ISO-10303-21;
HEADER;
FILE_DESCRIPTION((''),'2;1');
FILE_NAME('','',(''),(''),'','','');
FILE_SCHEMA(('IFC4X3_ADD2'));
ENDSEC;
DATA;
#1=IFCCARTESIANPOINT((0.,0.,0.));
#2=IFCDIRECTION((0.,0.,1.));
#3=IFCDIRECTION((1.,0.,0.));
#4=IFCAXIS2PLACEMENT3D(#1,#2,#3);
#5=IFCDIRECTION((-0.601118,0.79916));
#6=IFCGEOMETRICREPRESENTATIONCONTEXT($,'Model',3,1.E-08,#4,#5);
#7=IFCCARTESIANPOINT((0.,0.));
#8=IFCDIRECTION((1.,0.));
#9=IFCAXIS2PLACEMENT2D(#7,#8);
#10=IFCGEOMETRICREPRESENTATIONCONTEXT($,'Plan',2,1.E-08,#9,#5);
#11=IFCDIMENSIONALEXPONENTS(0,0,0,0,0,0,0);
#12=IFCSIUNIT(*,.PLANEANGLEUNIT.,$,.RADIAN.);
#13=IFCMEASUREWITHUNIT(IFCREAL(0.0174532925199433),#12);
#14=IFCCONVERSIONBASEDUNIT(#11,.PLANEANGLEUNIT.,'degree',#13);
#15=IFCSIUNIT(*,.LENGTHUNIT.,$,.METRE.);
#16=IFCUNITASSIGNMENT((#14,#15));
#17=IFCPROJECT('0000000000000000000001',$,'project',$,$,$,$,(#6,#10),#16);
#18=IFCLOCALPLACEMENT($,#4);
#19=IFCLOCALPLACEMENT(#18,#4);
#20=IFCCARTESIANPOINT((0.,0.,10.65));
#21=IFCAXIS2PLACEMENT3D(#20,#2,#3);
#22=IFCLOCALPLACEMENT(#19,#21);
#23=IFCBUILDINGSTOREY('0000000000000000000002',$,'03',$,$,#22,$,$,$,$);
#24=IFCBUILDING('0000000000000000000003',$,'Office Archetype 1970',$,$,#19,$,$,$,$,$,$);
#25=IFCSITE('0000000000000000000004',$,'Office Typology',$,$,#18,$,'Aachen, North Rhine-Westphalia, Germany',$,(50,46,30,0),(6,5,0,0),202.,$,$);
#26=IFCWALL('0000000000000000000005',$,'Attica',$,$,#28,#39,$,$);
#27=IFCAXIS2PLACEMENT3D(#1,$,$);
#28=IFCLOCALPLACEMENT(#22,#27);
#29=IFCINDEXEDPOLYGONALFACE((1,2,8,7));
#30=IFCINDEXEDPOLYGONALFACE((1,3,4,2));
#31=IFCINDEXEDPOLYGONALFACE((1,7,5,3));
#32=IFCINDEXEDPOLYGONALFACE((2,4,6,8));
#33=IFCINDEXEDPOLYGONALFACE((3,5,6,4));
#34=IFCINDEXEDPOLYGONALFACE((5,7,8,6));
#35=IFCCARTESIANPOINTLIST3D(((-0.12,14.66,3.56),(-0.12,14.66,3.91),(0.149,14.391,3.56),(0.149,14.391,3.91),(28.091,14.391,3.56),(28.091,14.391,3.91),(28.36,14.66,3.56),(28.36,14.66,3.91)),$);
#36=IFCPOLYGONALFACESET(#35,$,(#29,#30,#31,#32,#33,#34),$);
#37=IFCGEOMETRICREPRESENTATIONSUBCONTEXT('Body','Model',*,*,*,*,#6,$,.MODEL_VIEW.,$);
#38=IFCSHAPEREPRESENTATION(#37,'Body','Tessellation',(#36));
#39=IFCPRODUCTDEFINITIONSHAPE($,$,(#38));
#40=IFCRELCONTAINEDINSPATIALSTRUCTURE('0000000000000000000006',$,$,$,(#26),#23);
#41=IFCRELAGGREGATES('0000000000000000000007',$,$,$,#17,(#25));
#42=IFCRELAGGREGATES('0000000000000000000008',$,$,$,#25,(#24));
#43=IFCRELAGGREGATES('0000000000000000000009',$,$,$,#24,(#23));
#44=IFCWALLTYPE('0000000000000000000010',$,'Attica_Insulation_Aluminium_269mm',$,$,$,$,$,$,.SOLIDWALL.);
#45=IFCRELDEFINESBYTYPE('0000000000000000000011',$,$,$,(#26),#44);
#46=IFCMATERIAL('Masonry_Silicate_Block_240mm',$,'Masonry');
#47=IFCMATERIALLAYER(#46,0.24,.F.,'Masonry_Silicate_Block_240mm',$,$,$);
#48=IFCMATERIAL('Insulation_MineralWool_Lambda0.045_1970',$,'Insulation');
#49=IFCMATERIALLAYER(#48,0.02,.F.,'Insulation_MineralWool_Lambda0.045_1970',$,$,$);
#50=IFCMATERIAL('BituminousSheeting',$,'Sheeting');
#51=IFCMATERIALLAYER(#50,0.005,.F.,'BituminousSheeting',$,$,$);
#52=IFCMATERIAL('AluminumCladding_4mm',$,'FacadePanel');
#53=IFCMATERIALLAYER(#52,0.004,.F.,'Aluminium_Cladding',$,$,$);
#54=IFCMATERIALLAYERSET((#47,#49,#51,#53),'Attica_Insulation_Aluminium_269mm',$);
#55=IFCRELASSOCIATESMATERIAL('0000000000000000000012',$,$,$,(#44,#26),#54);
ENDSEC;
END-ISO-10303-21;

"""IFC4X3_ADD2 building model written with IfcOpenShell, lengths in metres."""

from ifc_helpers import new_model, entity, si_unit, converted_unit, direction, frame, origin_with_axes, origin_2d_with_axis, place, context, subcontext, project, spatial, line, indexed_curve, outline, extrude, material, layer, layer_set, layer_usage, type_object, element, save


model = new_model("IFC4X3_ADD2")

# Units and contexts
model_context = context("Model", 3, precision=1e-08, world=origin_with_axes(), true_north=direction((-0.601118, 0.79916)))
plan_context = context("Plan", 2, precision=1e-08, world=origin_2d_with_axis(), true_north=direction((-0.601118, 0.79916)))
body_context = subcontext(model_context, "Body", "Model", "MODEL_VIEW")
ifc_project = project(units=[converted_unit("PLANEANGLEUNIT", "degree", entity("IfcReal", 0.0174532925199433), si_unit("PLANEANGLEUNIT", "RADIAN"), dimensions=[0, 0, 0, 0, 0, 0, 0]), si_unit("LENGTHUNIT", "METRE")], contexts=[model_context, plan_context])

# Site, building, storey
site_placement = place(None, origin_with_axes())
site = spatial("IfcSite", under=ifc_project, at=site_placement, Name="Office Typology", LongName="Aachen, North Rhine-Westphalia, Germany", RefLatitude=(50, 46, 30, 0), RefLongitude=(6, 5, 0, 0), RefElevation=202.0)
building_placement = place(site_placement, origin_with_axes())
building = spatial("IfcBuilding", under=site, at=building_placement, Name="Office Archetype 1970")
storey_placement = place(building_placement, frame((0.0, 0.0, 10.65), z_axis=(0.0, 0.0, 1.0), x_axis=(1.0, 0.0, 0.0)))
storey = spatial("IfcBuildingStorey", under=building, at=storey_placement, Name="03")

# Shared definitions
ifc_material_1 = material(Name="Masonry_Silicate_Block_240mm", Category="Masonry")

# Shared definitions
ifc_material_2 = material(Name="Insulation_MineralWool_Lambda0.045_1970", Category="Insulation")

# Wall
ifc_layer_1 = layer(ifc_material_1, 0.24, ventilated=False, Name="Masonry_Silicate_Block_240mm")
ifc_layer_2 = layer(ifc_material_2, 0.02, ventilated=False, Name="Insulation_MineralWool_Lambda0.045_1970")
ifc_material_3 = material(Name="BituminousSheeting", Category="Sheeting")
ifc_layer_3 = layer(ifc_material_3, 0.005, ventilated=False, Name="BituminousSheeting")
ifc_material_4 = material(Name="AluminumCladding_4mm", Category="FacadePanel")
ifc_layer_4 = layer(ifc_material_4, 0.004, ventilated=False, Name="Aluminium_Cladding")
ifc_layer_set_1 = layer_set([ifc_layer_1, ifc_layer_2, ifc_layer_3, ifc_layer_4], Name="Attica_Insulation_Aluminium_269mm")
ifc_layer_usage_1 = layer_usage(ifc_layer_set_1, "AXIS2", "POSITIVE", 0.0)
wall_type_1 = type_object("IfcWallType", Name="Attica_Insulation_Aluminium_269mm", PredefinedType="SOLIDWALL", material=ifc_layer_set_1)
wall_1_placement = place(storey_placement, frame((28.36, 14.66, 3.56), z_axis=(0.0, 0.0, 1.0), x_axis=(-1.0, 0.0, 0.0)))
element("IfcWall", 1, at=wall_1_placement, inside=storey, type_object=wall_type_1, material=ifc_layer_usage_1, Name="Attica", context=body_context, shape_type="SweptSolid", body=[
    extrude(outline(indexed_curve([(0.0, 0.0), (0.269, 0.269), (28.211, 0.269), (28.48, 0.0)], segments=[line(1, 2, 3, 4, 1)])), origin_with_axes(), (0.0, 0.0, 1.0), 0.35),
])

save(model, "model.ifc")
